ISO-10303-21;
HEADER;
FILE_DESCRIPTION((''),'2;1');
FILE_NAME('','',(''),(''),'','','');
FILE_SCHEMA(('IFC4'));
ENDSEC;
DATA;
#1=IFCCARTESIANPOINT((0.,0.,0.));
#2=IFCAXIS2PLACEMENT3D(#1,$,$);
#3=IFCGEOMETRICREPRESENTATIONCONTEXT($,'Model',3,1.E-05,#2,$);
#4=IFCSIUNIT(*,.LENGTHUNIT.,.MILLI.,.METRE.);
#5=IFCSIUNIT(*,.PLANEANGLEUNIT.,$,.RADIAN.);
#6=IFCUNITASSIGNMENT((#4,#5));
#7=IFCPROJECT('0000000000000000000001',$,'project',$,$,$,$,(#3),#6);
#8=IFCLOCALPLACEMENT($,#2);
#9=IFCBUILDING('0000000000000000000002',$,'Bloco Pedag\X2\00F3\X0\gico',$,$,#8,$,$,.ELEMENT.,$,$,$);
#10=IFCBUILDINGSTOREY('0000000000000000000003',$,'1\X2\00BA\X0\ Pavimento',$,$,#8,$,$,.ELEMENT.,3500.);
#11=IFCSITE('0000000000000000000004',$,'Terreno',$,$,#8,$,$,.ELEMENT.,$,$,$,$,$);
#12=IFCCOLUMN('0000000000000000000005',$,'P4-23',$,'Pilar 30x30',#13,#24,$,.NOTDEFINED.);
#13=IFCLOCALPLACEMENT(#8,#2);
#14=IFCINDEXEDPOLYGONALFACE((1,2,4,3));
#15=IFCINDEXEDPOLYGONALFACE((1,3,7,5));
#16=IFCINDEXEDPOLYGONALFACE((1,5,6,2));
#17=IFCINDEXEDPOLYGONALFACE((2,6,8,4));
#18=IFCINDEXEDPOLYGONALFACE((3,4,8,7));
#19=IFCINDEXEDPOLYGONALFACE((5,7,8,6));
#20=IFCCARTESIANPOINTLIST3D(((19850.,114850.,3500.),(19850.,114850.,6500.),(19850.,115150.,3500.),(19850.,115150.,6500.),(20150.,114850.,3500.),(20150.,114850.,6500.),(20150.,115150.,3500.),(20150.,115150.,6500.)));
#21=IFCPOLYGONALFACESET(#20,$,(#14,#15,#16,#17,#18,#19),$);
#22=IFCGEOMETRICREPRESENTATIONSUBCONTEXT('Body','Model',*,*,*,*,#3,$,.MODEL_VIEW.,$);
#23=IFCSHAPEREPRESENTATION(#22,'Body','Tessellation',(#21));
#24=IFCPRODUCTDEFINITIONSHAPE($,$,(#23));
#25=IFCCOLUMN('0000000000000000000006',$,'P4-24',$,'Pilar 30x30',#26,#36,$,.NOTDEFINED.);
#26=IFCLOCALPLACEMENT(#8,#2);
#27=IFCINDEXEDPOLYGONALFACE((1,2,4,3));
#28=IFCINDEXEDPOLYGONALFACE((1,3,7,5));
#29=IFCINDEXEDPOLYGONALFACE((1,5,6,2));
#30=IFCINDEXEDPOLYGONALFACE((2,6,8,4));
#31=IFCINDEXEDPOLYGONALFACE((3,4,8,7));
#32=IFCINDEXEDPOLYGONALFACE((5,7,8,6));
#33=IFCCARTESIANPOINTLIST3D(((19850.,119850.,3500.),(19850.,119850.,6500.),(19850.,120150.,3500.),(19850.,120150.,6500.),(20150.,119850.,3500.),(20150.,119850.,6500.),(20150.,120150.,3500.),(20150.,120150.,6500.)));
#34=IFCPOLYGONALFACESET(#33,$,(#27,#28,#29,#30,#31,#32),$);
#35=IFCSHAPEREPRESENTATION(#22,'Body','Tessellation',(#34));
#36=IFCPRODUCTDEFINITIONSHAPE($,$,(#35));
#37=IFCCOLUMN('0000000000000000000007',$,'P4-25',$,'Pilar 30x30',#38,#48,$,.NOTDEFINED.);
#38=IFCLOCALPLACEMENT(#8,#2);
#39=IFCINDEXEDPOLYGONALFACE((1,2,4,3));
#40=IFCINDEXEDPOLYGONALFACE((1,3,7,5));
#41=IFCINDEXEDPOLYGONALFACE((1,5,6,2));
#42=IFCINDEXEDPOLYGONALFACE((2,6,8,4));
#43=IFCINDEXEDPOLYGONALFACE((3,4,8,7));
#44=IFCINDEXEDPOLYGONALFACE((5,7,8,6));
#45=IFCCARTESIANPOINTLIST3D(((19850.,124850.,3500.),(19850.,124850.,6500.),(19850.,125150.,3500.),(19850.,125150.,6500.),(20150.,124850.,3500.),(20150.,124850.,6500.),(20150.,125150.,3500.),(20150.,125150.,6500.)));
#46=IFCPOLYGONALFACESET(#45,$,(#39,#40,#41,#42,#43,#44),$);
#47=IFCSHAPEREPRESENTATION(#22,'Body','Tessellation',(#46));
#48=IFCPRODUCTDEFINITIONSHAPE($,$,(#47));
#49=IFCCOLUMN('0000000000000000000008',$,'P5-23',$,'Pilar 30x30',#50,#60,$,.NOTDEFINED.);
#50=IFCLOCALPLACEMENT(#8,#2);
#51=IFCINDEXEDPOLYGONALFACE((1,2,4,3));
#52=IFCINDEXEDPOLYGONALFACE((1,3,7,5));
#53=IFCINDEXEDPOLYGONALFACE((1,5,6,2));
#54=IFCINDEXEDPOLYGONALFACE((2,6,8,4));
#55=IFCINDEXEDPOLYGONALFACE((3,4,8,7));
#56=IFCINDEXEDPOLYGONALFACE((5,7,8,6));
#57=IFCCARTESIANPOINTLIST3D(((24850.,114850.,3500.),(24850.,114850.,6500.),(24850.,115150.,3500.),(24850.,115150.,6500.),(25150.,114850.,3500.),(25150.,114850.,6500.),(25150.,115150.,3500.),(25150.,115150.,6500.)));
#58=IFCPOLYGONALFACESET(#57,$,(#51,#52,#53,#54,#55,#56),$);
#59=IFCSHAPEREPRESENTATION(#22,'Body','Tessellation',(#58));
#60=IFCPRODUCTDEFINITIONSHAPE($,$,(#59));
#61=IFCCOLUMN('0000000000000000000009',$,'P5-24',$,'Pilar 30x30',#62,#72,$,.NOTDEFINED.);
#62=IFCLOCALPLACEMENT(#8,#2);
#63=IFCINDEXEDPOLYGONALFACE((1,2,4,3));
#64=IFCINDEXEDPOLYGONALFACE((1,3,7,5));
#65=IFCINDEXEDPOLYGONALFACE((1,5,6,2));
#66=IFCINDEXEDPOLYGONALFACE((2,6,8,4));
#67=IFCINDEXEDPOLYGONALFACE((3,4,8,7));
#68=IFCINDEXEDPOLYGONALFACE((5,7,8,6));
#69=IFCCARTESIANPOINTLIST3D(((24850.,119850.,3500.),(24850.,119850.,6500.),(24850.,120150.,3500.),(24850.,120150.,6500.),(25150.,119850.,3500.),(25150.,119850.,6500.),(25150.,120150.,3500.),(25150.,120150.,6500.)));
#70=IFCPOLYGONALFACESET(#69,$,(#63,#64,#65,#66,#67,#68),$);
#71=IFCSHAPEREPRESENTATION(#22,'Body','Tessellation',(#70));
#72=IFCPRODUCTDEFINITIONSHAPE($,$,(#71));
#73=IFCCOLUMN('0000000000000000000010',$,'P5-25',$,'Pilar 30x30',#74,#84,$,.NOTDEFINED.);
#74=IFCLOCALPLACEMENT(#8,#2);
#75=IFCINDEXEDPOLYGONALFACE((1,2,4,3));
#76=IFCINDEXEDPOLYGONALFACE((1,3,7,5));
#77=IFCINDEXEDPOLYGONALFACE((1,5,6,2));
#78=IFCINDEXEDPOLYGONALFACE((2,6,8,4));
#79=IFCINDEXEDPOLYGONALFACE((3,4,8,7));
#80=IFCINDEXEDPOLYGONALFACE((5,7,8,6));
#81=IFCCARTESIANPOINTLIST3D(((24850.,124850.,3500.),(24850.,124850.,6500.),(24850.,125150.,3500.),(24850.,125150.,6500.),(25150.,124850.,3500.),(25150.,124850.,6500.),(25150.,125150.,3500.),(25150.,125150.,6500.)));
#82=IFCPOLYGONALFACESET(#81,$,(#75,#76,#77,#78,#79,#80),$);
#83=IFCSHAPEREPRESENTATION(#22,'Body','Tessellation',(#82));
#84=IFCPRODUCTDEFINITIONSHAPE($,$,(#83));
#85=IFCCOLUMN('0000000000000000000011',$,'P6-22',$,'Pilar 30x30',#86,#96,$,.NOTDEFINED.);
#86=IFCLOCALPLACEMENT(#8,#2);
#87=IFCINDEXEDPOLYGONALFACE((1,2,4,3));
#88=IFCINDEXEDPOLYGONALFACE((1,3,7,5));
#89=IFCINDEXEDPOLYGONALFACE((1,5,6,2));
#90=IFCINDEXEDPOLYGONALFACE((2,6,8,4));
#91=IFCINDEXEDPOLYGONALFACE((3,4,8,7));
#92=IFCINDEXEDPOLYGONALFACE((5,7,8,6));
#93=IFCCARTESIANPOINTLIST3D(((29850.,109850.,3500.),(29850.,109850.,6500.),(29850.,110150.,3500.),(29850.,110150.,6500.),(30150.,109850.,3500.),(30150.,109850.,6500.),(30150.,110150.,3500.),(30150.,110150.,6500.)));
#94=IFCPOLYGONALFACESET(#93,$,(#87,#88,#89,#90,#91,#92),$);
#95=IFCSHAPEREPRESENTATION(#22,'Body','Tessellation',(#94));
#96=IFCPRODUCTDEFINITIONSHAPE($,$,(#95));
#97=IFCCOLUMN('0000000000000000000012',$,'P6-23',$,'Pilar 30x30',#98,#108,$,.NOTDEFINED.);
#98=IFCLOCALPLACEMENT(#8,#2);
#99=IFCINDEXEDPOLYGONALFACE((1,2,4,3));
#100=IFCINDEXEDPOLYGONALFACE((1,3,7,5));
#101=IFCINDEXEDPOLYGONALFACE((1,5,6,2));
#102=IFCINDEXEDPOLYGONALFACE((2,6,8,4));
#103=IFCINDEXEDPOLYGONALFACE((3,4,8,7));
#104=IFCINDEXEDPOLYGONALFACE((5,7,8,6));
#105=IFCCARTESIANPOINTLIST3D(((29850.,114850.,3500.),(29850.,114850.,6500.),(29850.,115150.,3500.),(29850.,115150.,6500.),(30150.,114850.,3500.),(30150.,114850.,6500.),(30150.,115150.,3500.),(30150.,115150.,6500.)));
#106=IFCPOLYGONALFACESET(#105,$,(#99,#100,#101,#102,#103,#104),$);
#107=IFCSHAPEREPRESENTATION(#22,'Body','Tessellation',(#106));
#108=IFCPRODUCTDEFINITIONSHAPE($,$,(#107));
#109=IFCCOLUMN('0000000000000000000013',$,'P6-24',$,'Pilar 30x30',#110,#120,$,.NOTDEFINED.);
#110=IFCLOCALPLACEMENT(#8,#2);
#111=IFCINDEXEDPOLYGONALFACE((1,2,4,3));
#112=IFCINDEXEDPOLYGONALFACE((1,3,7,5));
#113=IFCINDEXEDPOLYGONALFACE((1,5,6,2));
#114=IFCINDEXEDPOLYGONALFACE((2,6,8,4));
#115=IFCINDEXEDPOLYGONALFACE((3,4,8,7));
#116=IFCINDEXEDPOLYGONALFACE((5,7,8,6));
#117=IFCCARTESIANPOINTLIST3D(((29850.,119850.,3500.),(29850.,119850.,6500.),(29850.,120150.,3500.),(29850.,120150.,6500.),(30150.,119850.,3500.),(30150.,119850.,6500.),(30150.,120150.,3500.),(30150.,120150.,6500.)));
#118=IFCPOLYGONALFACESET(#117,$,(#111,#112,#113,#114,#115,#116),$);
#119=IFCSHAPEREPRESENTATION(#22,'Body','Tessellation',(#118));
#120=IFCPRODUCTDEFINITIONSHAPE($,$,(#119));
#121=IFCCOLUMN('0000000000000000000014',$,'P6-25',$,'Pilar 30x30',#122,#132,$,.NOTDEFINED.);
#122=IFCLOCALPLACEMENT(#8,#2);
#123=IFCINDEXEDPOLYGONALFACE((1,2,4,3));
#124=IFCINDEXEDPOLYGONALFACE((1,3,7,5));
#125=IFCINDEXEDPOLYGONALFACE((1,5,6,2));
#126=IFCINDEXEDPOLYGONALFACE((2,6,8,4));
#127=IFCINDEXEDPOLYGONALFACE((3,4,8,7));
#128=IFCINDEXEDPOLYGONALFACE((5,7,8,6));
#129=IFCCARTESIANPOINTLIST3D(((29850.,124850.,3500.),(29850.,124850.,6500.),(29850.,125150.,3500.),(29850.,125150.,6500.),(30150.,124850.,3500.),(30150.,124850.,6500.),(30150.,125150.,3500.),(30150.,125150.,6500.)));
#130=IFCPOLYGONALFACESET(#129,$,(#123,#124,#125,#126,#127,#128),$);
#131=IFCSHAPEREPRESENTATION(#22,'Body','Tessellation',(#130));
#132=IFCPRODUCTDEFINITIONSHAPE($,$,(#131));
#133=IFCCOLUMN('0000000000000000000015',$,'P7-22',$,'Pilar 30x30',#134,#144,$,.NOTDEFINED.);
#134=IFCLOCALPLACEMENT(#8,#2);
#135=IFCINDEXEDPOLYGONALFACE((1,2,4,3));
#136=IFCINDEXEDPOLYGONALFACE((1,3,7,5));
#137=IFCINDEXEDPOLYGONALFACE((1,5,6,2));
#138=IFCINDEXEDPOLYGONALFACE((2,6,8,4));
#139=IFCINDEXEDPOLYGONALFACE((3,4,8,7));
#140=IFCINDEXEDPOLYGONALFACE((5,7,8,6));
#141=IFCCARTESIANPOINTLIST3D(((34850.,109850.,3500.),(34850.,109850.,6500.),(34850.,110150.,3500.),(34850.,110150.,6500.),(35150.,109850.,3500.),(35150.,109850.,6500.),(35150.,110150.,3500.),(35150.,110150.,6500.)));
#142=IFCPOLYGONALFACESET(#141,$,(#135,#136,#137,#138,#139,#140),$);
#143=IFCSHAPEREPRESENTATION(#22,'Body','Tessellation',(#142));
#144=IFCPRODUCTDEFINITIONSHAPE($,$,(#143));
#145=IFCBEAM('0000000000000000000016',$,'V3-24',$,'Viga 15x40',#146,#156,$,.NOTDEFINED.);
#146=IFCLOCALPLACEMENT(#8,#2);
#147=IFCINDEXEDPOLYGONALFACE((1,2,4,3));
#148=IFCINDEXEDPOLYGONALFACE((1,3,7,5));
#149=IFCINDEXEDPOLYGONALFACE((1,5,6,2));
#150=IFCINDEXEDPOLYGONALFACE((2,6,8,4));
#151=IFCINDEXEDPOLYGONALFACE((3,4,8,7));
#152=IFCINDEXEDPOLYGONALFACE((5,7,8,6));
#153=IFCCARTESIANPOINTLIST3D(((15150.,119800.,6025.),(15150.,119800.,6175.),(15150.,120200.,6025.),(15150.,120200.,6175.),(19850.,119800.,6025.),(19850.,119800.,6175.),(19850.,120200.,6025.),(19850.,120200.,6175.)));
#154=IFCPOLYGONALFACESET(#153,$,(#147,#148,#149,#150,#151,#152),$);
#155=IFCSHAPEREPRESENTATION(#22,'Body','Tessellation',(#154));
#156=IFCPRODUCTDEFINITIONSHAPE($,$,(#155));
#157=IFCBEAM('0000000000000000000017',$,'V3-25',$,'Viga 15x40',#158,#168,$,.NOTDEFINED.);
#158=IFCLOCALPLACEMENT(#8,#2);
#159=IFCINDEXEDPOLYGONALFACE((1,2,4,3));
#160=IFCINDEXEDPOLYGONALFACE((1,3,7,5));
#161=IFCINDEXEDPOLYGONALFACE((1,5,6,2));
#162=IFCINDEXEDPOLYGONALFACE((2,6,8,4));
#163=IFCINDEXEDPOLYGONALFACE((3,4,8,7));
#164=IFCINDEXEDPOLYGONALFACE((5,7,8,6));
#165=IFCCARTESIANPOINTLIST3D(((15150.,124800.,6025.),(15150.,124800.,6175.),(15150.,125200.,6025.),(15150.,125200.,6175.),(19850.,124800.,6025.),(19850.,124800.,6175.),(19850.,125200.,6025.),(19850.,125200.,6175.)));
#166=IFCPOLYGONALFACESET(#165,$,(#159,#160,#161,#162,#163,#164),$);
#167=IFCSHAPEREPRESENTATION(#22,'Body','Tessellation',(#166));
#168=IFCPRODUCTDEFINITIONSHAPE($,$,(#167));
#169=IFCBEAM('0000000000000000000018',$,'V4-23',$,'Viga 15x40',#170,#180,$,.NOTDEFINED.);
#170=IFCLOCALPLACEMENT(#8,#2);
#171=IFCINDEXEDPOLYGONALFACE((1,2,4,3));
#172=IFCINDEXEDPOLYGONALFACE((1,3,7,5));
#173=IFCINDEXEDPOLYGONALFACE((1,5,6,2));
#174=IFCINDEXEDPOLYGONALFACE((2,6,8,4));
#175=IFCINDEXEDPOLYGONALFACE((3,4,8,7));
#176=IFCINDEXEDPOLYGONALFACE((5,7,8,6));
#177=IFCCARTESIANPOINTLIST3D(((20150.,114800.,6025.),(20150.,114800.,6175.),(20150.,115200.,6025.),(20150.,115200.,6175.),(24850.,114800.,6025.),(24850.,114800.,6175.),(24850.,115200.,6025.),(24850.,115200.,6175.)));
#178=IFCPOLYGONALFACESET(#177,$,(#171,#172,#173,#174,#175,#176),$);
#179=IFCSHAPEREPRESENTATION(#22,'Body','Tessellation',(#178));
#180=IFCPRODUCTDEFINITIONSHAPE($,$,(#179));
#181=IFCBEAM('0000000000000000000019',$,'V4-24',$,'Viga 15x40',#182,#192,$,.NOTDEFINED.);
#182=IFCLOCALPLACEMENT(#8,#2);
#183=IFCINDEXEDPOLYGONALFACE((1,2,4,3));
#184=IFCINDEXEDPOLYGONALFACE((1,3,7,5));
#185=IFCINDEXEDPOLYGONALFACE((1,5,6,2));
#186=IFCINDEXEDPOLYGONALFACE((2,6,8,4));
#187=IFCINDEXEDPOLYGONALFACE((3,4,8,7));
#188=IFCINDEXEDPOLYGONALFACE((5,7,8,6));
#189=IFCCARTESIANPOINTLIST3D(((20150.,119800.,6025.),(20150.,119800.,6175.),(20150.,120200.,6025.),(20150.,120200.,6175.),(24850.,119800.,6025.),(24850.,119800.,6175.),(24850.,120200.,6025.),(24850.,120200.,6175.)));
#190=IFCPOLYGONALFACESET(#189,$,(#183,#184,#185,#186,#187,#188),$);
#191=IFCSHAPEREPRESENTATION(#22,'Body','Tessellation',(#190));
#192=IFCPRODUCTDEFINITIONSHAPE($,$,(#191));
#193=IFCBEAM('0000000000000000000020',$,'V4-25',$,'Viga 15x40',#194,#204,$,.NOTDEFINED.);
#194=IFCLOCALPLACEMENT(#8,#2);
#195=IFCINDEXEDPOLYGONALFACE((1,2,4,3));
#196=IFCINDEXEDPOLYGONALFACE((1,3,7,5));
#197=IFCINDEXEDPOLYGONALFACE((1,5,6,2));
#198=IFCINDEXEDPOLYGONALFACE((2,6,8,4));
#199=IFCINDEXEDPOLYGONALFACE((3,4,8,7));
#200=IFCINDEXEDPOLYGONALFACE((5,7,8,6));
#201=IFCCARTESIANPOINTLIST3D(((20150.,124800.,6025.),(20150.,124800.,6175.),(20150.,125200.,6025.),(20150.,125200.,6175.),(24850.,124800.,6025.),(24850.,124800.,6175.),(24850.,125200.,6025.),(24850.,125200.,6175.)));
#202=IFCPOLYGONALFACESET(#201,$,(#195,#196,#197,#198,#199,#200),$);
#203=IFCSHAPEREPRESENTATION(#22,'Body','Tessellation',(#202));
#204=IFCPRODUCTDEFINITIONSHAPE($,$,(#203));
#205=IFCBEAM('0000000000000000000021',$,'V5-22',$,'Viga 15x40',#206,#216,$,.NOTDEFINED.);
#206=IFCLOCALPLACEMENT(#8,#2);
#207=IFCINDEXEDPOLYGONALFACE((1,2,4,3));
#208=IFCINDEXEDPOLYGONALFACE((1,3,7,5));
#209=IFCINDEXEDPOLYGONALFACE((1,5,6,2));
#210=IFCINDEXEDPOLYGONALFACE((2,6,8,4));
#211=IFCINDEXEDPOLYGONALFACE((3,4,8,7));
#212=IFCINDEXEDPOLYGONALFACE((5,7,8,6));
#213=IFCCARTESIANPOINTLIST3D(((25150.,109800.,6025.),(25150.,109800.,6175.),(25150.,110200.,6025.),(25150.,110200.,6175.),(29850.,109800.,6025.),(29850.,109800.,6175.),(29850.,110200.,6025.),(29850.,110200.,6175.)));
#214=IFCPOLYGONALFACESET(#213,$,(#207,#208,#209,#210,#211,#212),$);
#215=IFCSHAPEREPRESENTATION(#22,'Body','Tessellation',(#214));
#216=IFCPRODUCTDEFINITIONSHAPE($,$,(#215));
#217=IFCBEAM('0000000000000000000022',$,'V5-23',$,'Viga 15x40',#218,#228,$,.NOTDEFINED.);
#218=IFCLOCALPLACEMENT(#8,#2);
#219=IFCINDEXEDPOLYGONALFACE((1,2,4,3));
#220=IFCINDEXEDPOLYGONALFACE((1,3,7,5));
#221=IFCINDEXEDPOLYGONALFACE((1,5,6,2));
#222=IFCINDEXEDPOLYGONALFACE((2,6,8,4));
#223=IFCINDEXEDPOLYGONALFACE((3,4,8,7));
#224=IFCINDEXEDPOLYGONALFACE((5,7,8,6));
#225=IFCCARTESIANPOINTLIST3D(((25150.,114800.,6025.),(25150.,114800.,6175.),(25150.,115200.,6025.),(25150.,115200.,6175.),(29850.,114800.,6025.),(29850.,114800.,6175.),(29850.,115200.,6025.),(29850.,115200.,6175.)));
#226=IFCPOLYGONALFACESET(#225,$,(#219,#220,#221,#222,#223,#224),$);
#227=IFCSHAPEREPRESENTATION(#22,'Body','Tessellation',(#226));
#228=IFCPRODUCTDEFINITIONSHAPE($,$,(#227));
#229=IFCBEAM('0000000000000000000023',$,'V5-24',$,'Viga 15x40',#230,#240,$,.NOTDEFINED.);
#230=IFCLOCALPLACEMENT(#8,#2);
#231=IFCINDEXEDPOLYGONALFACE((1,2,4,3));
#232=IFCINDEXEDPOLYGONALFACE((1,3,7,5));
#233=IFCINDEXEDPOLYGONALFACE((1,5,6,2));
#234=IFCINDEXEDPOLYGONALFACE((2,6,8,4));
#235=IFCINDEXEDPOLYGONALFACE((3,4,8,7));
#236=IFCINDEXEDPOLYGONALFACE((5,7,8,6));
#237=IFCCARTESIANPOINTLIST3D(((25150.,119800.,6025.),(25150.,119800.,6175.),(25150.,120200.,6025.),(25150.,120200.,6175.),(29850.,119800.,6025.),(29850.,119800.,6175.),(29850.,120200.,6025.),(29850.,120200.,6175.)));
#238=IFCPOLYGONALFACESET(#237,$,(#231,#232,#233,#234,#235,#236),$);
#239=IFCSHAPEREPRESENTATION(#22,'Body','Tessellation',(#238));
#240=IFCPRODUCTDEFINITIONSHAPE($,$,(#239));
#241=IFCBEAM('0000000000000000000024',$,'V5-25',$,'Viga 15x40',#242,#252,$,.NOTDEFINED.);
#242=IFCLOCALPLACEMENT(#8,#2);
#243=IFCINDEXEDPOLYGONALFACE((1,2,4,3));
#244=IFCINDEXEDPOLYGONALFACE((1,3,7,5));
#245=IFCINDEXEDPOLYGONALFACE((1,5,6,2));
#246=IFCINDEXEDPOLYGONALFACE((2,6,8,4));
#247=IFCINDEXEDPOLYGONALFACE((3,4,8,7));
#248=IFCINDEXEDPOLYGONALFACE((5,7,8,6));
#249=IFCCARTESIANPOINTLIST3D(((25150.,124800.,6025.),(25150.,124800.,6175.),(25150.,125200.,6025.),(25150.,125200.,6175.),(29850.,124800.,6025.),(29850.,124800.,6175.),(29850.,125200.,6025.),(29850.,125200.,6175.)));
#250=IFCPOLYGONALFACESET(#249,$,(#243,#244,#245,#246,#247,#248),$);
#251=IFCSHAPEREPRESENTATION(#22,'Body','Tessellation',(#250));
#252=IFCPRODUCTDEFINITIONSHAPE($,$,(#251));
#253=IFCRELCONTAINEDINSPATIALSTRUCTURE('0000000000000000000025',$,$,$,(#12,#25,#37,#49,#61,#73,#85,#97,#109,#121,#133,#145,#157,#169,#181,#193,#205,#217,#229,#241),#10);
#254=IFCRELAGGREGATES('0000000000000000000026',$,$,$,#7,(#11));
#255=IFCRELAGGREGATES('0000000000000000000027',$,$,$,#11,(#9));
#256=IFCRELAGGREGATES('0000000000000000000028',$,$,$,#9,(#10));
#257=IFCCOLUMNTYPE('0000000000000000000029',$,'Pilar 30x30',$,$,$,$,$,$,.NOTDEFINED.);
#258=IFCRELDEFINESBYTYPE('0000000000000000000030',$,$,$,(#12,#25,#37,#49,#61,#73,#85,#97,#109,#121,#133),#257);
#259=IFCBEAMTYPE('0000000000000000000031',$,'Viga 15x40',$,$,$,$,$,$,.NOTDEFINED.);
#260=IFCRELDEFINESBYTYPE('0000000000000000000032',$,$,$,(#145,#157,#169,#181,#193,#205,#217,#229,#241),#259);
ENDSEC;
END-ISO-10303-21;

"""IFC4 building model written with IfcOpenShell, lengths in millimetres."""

from ifc_helpers import new_model, si_unit, frame, origin, origin_2d, place, context, subcontext, project, spatial, rectangle, extrude, type_object, element, save


model = new_model("IFC4")

# Units and contexts
model_context = context("Model", 3, precision=1e-05, world=origin())
body_context = subcontext(model_context, "Body", "Model", "MODEL_VIEW")
ifc_project = project(units=[si_unit("LENGTHUNIT", "METRE", prefix="MILLI"), si_unit("PLANEANGLEUNIT", "RADIAN")], contexts=[model_context])

# Site, building, storey
placement = place(None, origin())
site = spatial("IfcSite", under=ifc_project, at=placement, Name="Terreno", CompositionType="ELEMENT")
building = spatial("IfcBuilding", under=site, at=placement, Name="Bloco Pedagógico", CompositionType="ELEMENT")
storey = spatial("IfcBuildingStorey", under=building, at=placement, Name="1º Pavimento", CompositionType="ELEMENT", Elevation=3500.0)

# Columns
column_type = type_object("IfcColumnType", Name="Pilar 30x30", PredefinedType="NOTDEFINED")
for number, where, z_axis, x_axis, name in (
    (1, (20000.0, 115000.0, 3500.0), (0.0, 0.0, 1.0), (1.0, 0.0, 0.0), "P4-23"),
    (2, (20000.0, 120000.0, 3500.0), (0.0, 0.0, 1.0), (1.0, 0.0, 0.0), "P4-24"),
    (3, (20000.0, 125000.0, 3500.0), (0.0, 0.0, 1.0), (1.0, 0.0, 0.0), "P4-25"),
    (4, (25000.0, 115000.0, 3500.0), (0.0, 0.0, 1.0), (1.0, 0.0, 0.0), "P5-23"),
    (5, (25000.0, 120000.0, 3500.0), (0.0, 0.0, 1.0), (1.0, 0.0, 0.0), "P5-24"),
    (6, (25000.0, 125000.0, 3500.0), (0.0, 0.0, 1.0), (1.0, 0.0, 0.0), "P5-25"),
    (7, (30000.0, 110000.0, 3500.0), (0.0, 0.0, 1.0), (1.0, 0.0, 0.0), "P6-22"),
    (8, (30000.0, 115000.0, 3500.0), (0.0, 0.0, 1.0), (1.0, 0.0, 0.0), "P6-23"),
    (9, (30000.0, 120000.0, 3500.0), (0.0, 0.0, 1.0), (1.0, 0.0, 0.0), "P6-24"),
    (10, (30000.0, 125000.0, 3500.0), (0.0, 0.0, 1.0), (1.0, 0.0, 0.0), "P6-25"),
    (11, (35000.0, 110000.0, 3500.0), (0.0, 0.0, 1.0), (1.0, 0.0, 0.0), "P7-22"),
):
    element("IfcColumn", number, at=place(None, frame(where, z_axis=z_axis, x_axis=x_axis)), inside=storey, type_object=column_type, Name=name, ObjectType="Pilar 30x30", PredefinedType="NOTDEFINED", context=body_context, shape_type="SweptSolid", body=[
        extrude(rectangle(XDim=300.0, YDim=300.0, at=origin_2d()), None, (0.0, 0.0, 1.0), 3000.0),
    ])

# Beams
beam_type = type_object("IfcBeamType", Name="Viga 15x40", PredefinedType="NOTDEFINED")
for number, where, z_axis, x_axis, name in (
    (12, (15150.0, 120000.0, 6100.0), (1.0, 0.0, 0.0), (0.0, 1.0, 0.0), "V3-24"),
    (13, (15150.0, 125000.0, 6100.0), (1.0, 0.0, 0.0), (0.0, 1.0, 0.0), "V3-25"),
    (14, (20150.0, 115000.0, 6100.0), (1.0, 0.0, 0.0), (0.0, 1.0, 0.0), "V4-23"),
    (15, (20150.0, 120000.0, 6100.0), (1.0, 0.0, 0.0), (0.0, 1.0, 0.0), "V4-24"),
    (16, (20150.0, 125000.0, 6100.0), (1.0, 0.0, 0.0), (0.0, 1.0, 0.0), "V4-25"),
    (17, (25150.0, 110000.0, 6100.0), (1.0, 0.0, 0.0), (0.0, 1.0, 0.0), "V5-22"),
    (18, (25150.0, 115000.0, 6100.0), (1.0, 0.0, 0.0), (0.0, 1.0, 0.0), "V5-23"),
    (19, (25150.0, 120000.0, 6100.0), (1.0, 0.0, 0.0), (0.0, 1.0, 0.0), "V5-24"),
    (20, (25150.0, 125000.0, 6100.0), (1.0, 0.0, 0.0), (0.0, 1.0, 0.0), "V5-25"),
):
    element("IfcBeam", number, at=place(None, frame(where, z_axis=z_axis, x_axis=x_axis)), inside=storey, type_object=beam_type, Name=name, ObjectType="Viga 15x40", PredefinedType="NOTDEFINED", context=body_context, shape_type="SweptSolid", body=[
        extrude(rectangle(XDim=400.0, YDim=150.0, at=origin_2d()), None, (0.0, 0.0, 1.0), 4700.0),
    ])

save(model, "model.ifc")
